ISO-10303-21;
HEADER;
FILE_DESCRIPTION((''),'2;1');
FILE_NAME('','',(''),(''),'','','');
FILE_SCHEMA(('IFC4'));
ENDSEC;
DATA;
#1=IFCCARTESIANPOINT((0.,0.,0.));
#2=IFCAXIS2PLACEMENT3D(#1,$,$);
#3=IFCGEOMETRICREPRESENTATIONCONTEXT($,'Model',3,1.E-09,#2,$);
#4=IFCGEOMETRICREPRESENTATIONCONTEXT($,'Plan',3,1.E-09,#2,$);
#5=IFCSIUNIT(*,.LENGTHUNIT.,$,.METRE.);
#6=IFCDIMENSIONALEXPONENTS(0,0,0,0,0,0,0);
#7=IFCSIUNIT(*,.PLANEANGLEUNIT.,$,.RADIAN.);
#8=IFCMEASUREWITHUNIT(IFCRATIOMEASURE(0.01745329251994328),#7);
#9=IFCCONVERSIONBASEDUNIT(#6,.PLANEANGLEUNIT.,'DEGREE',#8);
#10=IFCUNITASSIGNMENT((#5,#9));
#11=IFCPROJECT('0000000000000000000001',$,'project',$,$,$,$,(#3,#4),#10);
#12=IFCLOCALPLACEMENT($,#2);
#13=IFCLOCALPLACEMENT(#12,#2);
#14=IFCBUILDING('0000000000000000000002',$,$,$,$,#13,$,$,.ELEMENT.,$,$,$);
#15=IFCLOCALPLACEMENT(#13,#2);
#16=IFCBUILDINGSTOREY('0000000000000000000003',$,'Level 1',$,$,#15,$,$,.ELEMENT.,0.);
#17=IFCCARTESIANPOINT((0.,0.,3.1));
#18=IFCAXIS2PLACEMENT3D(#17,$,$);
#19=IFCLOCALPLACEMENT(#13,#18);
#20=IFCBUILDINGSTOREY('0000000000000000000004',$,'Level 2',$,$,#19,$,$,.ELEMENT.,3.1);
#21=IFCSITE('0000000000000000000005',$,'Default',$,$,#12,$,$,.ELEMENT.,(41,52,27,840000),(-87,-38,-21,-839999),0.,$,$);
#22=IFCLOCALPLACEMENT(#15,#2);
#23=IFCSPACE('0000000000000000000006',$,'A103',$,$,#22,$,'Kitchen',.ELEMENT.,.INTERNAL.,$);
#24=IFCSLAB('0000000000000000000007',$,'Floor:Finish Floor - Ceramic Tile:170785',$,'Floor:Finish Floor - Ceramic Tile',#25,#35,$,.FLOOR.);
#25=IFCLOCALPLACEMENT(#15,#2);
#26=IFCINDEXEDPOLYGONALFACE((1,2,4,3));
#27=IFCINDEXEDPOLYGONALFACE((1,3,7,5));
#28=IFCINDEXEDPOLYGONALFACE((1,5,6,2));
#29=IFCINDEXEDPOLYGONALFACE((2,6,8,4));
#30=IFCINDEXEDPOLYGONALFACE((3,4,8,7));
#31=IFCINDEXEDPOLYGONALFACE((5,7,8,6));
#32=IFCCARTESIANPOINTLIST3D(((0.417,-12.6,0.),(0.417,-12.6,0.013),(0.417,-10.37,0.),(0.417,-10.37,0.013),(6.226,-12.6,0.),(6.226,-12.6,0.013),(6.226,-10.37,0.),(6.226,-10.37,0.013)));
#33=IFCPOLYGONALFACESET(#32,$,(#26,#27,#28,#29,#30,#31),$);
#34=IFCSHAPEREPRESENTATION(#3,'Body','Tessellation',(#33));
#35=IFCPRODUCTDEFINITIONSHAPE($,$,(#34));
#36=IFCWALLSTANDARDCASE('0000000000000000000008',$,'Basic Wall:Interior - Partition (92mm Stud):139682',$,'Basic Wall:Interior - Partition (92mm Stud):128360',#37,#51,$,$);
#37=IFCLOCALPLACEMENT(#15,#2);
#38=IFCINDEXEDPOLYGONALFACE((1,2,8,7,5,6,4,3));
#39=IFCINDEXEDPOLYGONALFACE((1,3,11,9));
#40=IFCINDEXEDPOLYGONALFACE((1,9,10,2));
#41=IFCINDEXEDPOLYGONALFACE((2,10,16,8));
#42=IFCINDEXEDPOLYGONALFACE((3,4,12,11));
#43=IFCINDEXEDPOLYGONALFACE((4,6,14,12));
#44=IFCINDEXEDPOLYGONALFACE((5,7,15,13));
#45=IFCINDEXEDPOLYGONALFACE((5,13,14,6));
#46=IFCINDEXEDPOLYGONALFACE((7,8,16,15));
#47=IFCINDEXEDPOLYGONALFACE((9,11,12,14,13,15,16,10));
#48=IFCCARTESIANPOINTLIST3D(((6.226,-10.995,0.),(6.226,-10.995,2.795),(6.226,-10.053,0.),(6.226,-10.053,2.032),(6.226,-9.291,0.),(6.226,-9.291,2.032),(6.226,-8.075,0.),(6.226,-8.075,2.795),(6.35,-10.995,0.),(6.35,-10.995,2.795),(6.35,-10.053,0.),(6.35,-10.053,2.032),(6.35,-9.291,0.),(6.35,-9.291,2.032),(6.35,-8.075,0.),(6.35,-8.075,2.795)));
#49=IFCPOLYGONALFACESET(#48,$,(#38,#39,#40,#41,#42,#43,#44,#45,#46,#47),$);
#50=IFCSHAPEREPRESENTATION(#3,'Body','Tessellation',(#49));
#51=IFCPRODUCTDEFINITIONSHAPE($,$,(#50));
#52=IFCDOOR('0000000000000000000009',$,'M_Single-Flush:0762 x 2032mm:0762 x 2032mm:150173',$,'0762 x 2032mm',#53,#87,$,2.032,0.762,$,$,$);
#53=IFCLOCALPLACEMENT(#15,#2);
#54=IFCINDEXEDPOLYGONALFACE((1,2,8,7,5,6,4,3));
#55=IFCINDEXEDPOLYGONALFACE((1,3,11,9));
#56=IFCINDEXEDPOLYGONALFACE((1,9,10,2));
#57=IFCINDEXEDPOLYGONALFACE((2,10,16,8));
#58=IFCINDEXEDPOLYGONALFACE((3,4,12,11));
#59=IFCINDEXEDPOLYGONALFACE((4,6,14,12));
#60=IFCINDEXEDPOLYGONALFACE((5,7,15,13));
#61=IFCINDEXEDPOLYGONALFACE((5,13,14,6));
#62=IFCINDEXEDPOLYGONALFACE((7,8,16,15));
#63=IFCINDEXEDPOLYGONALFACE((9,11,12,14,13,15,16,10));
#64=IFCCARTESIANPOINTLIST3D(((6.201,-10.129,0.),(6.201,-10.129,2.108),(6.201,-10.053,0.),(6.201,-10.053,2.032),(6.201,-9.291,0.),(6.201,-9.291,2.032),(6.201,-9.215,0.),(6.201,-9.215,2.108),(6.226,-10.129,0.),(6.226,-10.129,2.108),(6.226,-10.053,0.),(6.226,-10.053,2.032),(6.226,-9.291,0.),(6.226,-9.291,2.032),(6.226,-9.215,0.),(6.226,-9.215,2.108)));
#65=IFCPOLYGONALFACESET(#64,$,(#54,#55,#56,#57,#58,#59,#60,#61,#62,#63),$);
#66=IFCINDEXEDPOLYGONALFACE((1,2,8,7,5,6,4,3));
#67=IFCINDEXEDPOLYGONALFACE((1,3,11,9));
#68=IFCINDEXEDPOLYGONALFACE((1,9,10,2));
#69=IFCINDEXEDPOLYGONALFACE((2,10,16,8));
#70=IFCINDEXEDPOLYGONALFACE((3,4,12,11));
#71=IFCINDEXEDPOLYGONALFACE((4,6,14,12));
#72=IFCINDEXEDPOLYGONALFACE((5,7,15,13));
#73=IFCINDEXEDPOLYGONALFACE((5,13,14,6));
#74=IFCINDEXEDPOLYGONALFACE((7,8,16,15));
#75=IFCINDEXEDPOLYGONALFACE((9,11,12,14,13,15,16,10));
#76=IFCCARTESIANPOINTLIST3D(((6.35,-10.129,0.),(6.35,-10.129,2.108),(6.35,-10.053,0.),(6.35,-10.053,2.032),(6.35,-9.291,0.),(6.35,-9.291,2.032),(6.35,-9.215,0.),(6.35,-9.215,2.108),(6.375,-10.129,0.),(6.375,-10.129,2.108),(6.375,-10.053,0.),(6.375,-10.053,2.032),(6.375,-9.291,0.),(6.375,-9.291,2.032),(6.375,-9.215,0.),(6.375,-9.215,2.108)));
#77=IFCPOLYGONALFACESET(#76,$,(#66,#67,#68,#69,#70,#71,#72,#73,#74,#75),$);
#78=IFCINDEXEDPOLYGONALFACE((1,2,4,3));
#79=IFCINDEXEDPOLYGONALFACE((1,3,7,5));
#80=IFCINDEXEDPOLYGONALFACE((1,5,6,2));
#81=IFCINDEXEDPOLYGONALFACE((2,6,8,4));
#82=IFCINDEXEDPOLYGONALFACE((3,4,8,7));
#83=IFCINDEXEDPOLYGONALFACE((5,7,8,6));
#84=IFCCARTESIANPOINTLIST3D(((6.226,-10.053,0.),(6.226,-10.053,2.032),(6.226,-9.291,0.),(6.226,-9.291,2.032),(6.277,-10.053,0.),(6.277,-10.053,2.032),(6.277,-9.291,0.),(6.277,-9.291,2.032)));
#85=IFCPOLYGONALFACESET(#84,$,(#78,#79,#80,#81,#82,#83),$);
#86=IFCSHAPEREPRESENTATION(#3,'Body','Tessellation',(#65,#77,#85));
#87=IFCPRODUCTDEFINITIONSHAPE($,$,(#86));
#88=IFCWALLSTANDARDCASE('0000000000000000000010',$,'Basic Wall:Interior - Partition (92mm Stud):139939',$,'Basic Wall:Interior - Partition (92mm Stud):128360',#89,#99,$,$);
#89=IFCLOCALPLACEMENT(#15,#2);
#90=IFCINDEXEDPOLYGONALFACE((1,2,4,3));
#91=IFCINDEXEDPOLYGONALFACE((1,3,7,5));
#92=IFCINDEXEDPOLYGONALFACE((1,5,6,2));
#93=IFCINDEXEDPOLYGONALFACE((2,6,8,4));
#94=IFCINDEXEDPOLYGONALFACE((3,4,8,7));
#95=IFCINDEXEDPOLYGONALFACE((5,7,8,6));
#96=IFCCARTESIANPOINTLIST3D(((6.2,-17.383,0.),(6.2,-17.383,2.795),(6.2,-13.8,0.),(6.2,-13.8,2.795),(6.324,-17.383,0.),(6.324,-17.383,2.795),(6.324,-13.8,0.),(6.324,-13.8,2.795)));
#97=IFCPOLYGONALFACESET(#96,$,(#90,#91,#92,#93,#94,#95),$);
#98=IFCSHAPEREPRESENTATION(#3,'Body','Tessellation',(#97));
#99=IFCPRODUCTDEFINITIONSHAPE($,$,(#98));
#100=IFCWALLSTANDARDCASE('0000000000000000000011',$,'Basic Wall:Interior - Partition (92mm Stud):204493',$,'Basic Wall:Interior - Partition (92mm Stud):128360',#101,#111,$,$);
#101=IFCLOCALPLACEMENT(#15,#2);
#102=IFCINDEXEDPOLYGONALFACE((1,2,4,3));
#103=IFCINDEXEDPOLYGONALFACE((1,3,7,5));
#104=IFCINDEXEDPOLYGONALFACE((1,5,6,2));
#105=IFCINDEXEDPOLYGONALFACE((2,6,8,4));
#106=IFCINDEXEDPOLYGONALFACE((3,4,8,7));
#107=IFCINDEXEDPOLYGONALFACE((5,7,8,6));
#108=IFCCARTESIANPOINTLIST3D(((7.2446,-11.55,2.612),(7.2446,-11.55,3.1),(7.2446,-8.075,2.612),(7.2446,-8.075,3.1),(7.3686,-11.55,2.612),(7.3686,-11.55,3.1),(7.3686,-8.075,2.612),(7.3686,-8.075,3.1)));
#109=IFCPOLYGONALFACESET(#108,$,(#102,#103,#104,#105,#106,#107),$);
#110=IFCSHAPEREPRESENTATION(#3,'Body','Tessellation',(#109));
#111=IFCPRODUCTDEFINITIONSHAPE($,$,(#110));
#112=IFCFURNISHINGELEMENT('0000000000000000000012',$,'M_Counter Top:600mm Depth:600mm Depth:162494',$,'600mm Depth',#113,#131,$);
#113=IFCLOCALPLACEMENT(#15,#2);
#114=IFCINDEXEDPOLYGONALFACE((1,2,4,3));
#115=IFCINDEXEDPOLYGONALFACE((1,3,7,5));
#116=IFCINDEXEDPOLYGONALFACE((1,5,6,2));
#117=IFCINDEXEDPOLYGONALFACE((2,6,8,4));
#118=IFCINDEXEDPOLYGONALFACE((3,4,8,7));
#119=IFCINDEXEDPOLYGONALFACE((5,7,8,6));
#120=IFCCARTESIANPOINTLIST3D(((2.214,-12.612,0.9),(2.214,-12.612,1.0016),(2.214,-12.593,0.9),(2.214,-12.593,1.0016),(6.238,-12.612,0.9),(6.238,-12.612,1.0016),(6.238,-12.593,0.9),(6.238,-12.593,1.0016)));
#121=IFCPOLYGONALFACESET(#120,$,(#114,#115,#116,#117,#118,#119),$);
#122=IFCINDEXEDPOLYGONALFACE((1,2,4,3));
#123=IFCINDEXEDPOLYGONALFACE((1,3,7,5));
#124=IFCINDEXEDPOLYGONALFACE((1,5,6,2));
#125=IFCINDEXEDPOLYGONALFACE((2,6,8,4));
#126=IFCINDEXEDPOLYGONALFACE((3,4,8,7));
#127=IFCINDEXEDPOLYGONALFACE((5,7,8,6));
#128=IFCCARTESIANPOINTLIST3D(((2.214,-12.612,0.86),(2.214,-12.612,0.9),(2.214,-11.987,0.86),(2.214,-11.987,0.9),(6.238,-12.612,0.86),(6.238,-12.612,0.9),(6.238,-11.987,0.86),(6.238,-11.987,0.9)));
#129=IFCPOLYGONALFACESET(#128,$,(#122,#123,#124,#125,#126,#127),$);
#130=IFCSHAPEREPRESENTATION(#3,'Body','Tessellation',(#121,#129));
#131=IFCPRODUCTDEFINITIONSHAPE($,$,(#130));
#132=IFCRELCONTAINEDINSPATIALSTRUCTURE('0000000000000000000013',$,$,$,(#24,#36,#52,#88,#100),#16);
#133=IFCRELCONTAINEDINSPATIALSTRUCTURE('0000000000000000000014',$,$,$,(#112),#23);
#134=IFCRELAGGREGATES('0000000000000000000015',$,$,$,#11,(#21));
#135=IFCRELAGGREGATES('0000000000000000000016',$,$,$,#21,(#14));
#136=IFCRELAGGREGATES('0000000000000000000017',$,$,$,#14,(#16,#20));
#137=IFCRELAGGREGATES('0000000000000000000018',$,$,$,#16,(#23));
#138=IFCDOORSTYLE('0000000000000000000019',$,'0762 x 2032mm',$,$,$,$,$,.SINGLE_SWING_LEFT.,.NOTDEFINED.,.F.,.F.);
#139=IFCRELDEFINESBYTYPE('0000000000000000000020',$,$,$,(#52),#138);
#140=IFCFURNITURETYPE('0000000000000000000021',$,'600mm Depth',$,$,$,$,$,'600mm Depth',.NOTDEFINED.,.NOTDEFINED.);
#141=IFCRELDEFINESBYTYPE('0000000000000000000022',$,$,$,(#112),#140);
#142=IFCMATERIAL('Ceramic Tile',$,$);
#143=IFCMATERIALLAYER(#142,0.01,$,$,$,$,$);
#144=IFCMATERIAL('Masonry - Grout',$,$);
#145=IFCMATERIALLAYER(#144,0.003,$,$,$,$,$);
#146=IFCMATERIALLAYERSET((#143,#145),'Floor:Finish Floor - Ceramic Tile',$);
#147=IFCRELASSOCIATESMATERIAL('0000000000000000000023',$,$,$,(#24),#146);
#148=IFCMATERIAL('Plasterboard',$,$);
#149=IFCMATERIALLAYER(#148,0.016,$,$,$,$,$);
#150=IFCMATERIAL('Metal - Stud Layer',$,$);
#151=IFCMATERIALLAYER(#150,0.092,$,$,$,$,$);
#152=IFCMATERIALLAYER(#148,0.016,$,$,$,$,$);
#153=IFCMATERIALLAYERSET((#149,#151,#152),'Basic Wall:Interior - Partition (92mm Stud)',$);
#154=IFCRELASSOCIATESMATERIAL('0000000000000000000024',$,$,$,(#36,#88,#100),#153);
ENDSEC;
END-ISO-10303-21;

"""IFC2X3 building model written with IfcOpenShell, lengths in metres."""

from ifc_helpers import new_model, entity, si_unit, converted_unit, frame, frame_2d, origin, origin_2d_with_axis, place, context, project, spatial, polyline, rectangle, outline, extrude, source, transform, mapped, material, layer, layer_set, layer_usage, type_object, type_shapes, element, fill, save


model = new_model("IFC2X3")

# Units and contexts
model_context = context("Model", 3, precision=1e-09, world=origin())
plan_context = context("Plan", 3, precision=1e-09, world=origin())
ifc_project = project(units=[si_unit("LENGTHUNIT", "METRE"), converted_unit("PLANEANGLEUNIT", "DEGREE", entity("IfcRatioMeasure", 0.01745329251994328), si_unit("PLANEANGLEUNIT", "RADIAN"), dimensions=[0, 0, 0, 0, 0, 0, 0])], contexts=[model_context, plan_context])

# Site, building, storey
site_placement = place(None, origin())
site = spatial("IfcSite", under=ifc_project, at=site_placement, Name="Default", CompositionType="ELEMENT", RefLatitude=(41, 52, 27, 840000), RefLongitude=(-87, -38, -21, -839999), RefElevation=0.0)
building_placement = place(site_placement, origin())
building = spatial("IfcBuilding", under=site, at=building_placement, CompositionType="ELEMENT")
storey_1_placement = place(building_placement, origin())
storey_1 = spatial("IfcBuildingStorey", under=building, at=storey_1_placement, Name="Level 1", CompositionType="ELEMENT", Elevation=0.0)

# Slab
ifc_material_1 = material(Name="Ceramic Tile")
ifc_layer_1 = layer(ifc_material_1, 0.01)
ifc_material_2 = material(Name="Masonry - Grout")
ifc_layer_2 = layer(ifc_material_2, 0.003)
ifc_layer_set_1 = layer_set([ifc_layer_1, ifc_layer_2], Name="Floor:Finish Floor - Ceramic Tile")
ifc_layer_usage_1 = layer_usage(ifc_layer_set_1, "AXIS3", "POSITIVE", 0.0)
slab_placement = place(storey_1_placement, frame((0.417, -12.6, 0.0)))
element("IfcSlab", 1, at=slab_placement, inside=storey_1, material=ifc_layer_usage_1, Name="Floor:Finish Floor - Ceramic Tile:170785", ObjectType="Floor:Finish Floor - Ceramic Tile", PredefinedType="FLOOR", context=model_context, shape_type="SweptSolid", body=[
    extrude(rectangle(XDim=5.809, YDim=2.23, at=frame_2d((0.0, 0.0), x_axis=(-1.0, 0.0))), frame((2.9045, 1.115, 0.013), z_axis=(0.0, 0.0, -1.0), x_axis=(-1.0, 0.0, 0.0)), (0.0, 0.0, 1.0), 0.013),
])

# Wall, opening, door
ifc_material_3 = material(Name="Plasterboard")
ifc_layer_3 = layer(ifc_material_3, 0.016)
ifc_material_4 = material(Name="Metal - Stud Layer")
ifc_layer_4 = layer(ifc_material_4, 0.092)
ifc_layer_5 = layer(ifc_material_3, 0.016)
ifc_layer_set_2 = layer_set([ifc_layer_3, ifc_layer_4, ifc_layer_5], Name="Basic Wall:Interior - Partition (92mm Stud)")
ifc_layer_usage_2 = layer_usage(ifc_layer_set_2, "AXIS2", "NEGATIVE", 0.062)
wall_1_placement = place(storey_1_placement, frame((6.288, -10.995, 0.0), z_axis=(0.0, 0.0, 1.0), x_axis=(0.0, 1.0, 0.0)))
wall_1 = element("IfcWallStandardCase", 2, at=wall_1_placement, inside=storey_1, material=ifc_layer_usage_2, Name="Basic Wall:Interior - Partition (92mm Stud):139682", ObjectType="Basic Wall:Interior - Partition (92mm Stud):128360", context=model_context, shape_type="SweptSolid", body=[
    extrude(rectangle(XDim=2.92, YDim=0.124, at=frame_2d((1.46, 0.0), x_axis=(-1.0, 0.0))), origin(), (0.0, 0.0, 1.0), 2.795),
])
opening_1_placement = place(wall_1_placement, frame((0.942, -0.062, 0.0)))
opening_1 = element("IfcOpeningElement", 3, at=opening_1_placement, cuts=wall_1, ObjectType="Opening", context=model_context, shape_type="SweptSolid", body=[
    extrude(rectangle(XDim=0.762, YDim=2.032, at=frame_2d((1.016, 0.381), x_axis=(0.0, -1.0))), frame((0.0, 0.0, 0.0), z_axis=(0.0, 1.0, 0.0), x_axis=(0.0, 0.0, 1.0)), (0.0, 0.0, 1.0), 0.124),
])
door_style_1 = type_object("IfcDoorStyle", Name="0762 x 2032mm", ConstructionType="NOTDEFINED", OperationType="SINGLE_SWING_LEFT", ParameterTakesPrecedence=False, Sizeable=False)
shared_shape_1 = source(origin(), model_context, "Body", "SweptSolid", [
    extrude(outline(polyline([(-0.457, -1.073), (0.457, -1.073), (0.457, 1.035), (0.381, 1.035), (0.381, -0.997), (-0.381, -0.997), (-0.381, 1.035), (-0.457, 1.035), (-0.457, -1.073)])), frame((0.381, 0.149, 1.035), z_axis=(0.0, -1.0, 0.0), x_axis=(-1.0, 0.0, 0.0)), (0.0, 0.0, 1.0), 0.025),
    extrude(outline(polyline([(-1.073, -0.457), (1.035, -0.457), (1.035, -0.381), (-0.997, -0.381), (-0.997, 0.381), (1.035, 0.381), (1.035, 0.457), (-1.073, 0.457), (-1.073, -0.457)])), frame((0.381, 0.0, 1.035), z_axis=(0.0, -1.0, 0.0), x_axis=(0.0, 0.0, -1.0)), (0.0, 0.0, 1.0), 0.025),
    extrude(rectangle(XDim=0.762, YDim=0.051, at=origin_2d_with_axis()), frame((0.381, 0.0985, 0.0)), (0.0, 0.0, 1.0), 2.032),
])
type_shapes(door_style_1, [shared_shape_1])
door_1_placement = place(opening_1_placement, origin())
door_1 = element("IfcDoor", 4, at=door_1_placement, inside=storey_1, type_object=door_style_1, Name="M_Single-Flush:0762 x 2032mm:0762 x 2032mm:150173", ObjectType="0762 x 2032mm", OverallHeight=2.032, OverallWidth=0.762, context=model_context, shape_type="MappedRepresentation", body=[
    mapped(shared_shape_1, transform((0.0, 0.0, 0.0), scale=1.0)),
])
fill(opening_1, door_1)

# Wall
ifc_layer_usage_3 = layer_usage(ifc_layer_set_2, "AXIS2", "NEGATIVE", 0.062)
wall_2_placement = place(storey_1_placement, frame((6.262, -13.8, 0.0), z_axis=(0.0, 0.0, 1.0), x_axis=(0.0, -1.0, 0.0)))
element("IfcWallStandardCase", 5, at=wall_2_placement, inside=storey_1, material=ifc_layer_usage_3, Name="Basic Wall:Interior - Partition (92mm Stud):139939", ObjectType="Basic Wall:Interior - Partition (92mm Stud):128360", context=model_context, shape_type="SweptSolid", body=[
    extrude(rectangle(XDim=3.583, YDim=0.124, at=frame_2d((1.7915, 0.0), x_axis=(-1.0, 0.0))), origin(), (0.0, 0.0, 1.0), 2.795),
])

# Shared definitions
storey_2_placement = place(building_placement, frame((0.0, 0.0, 3.1)))
storey_2 = spatial("IfcBuildingStorey", under=building, at=storey_2_placement, Name="Level 2", CompositionType="ELEMENT", Elevation=3.1)

# Wall
ifc_layer_usage_4 = layer_usage(ifc_layer_set_2, "AXIS2", "NEGATIVE", 0.062)
wall_3_placement = place(storey_1_placement, frame((7.3066, -11.55, 2.612), z_axis=(0.0, 0.0, 1.0), x_axis=(0.0, 1.0, 0.0)))
element("IfcWallStandardCase", 6, at=wall_3_placement, inside=storey_1, material=ifc_layer_usage_4, Name="Basic Wall:Interior - Partition (92mm Stud):204493", ObjectType="Basic Wall:Interior - Partition (92mm Stud):128360", context=model_context, shape_type="SweptSolid", body=[
    extrude(rectangle(XDim=3.475, YDim=0.124, at=frame_2d((1.7375, 0.0), x_axis=(-1.0, 0.0))), origin(), (0.0, 0.0, 1.0), 0.488),
])

# Shared definitions
space_1_placement = place(storey_1_placement, origin())
space_1 = spatial("IfcSpace", under=storey_1, at=space_1_placement, Name="A103", LongName="Kitchen", CompositionType="ELEMENT", InteriorOrExteriorSpace="INTERNAL")

# Furnishing element
furniture_type_1 = type_object("IfcFurnitureType", Name="600mm Depth", ElementType="600mm Depth", AssemblyPlace="NOTDEFINED")
shared_shape_2 = source(origin(), model_context, "Body", "SweptSolid", [
    extrude(rectangle(XDim=0.0191, YDim=4.024, at=origin_2d_with_axis()), frame((0.8115, -0.0095, 0.9), z_axis=(0.0, 0.0, 1.0), x_axis=(0.0, -1.0, 0.0)), (0.0, 0.0, 1.0), 0.1016),
    extrude(rectangle(XDim=4.024, YDim=0.625, at=origin_2d_with_axis()), frame((0.8115, -0.3125, 0.86), z_axis=(0.0, 0.0, 1.0), x_axis=(-1.0, 0.0, 0.0)), (0.0, 0.0, 1.0), 0.04),
])
type_shapes(furniture_type_1, [shared_shape_2])
furnishing_1_placement = place(space_1_placement, frame((5.0375, -12.612, 0.0), z_axis=(0.0, 0.0, 1.0), x_axis=(-1.0, 0.0, 0.0)))
element("IfcFurnishingElement", 7, at=furnishing_1_placement, inside=space_1, type_object=furniture_type_1, Name="M_Counter Top:600mm Depth:600mm Depth:162494", ObjectType="600mm Depth", context=model_context, shape_type="MappedRepresentation", body=[
    mapped(shared_shape_2, transform((0.0, 0.0, 0.0), scale=1.0)),
])

save(model, "model.ifc")
